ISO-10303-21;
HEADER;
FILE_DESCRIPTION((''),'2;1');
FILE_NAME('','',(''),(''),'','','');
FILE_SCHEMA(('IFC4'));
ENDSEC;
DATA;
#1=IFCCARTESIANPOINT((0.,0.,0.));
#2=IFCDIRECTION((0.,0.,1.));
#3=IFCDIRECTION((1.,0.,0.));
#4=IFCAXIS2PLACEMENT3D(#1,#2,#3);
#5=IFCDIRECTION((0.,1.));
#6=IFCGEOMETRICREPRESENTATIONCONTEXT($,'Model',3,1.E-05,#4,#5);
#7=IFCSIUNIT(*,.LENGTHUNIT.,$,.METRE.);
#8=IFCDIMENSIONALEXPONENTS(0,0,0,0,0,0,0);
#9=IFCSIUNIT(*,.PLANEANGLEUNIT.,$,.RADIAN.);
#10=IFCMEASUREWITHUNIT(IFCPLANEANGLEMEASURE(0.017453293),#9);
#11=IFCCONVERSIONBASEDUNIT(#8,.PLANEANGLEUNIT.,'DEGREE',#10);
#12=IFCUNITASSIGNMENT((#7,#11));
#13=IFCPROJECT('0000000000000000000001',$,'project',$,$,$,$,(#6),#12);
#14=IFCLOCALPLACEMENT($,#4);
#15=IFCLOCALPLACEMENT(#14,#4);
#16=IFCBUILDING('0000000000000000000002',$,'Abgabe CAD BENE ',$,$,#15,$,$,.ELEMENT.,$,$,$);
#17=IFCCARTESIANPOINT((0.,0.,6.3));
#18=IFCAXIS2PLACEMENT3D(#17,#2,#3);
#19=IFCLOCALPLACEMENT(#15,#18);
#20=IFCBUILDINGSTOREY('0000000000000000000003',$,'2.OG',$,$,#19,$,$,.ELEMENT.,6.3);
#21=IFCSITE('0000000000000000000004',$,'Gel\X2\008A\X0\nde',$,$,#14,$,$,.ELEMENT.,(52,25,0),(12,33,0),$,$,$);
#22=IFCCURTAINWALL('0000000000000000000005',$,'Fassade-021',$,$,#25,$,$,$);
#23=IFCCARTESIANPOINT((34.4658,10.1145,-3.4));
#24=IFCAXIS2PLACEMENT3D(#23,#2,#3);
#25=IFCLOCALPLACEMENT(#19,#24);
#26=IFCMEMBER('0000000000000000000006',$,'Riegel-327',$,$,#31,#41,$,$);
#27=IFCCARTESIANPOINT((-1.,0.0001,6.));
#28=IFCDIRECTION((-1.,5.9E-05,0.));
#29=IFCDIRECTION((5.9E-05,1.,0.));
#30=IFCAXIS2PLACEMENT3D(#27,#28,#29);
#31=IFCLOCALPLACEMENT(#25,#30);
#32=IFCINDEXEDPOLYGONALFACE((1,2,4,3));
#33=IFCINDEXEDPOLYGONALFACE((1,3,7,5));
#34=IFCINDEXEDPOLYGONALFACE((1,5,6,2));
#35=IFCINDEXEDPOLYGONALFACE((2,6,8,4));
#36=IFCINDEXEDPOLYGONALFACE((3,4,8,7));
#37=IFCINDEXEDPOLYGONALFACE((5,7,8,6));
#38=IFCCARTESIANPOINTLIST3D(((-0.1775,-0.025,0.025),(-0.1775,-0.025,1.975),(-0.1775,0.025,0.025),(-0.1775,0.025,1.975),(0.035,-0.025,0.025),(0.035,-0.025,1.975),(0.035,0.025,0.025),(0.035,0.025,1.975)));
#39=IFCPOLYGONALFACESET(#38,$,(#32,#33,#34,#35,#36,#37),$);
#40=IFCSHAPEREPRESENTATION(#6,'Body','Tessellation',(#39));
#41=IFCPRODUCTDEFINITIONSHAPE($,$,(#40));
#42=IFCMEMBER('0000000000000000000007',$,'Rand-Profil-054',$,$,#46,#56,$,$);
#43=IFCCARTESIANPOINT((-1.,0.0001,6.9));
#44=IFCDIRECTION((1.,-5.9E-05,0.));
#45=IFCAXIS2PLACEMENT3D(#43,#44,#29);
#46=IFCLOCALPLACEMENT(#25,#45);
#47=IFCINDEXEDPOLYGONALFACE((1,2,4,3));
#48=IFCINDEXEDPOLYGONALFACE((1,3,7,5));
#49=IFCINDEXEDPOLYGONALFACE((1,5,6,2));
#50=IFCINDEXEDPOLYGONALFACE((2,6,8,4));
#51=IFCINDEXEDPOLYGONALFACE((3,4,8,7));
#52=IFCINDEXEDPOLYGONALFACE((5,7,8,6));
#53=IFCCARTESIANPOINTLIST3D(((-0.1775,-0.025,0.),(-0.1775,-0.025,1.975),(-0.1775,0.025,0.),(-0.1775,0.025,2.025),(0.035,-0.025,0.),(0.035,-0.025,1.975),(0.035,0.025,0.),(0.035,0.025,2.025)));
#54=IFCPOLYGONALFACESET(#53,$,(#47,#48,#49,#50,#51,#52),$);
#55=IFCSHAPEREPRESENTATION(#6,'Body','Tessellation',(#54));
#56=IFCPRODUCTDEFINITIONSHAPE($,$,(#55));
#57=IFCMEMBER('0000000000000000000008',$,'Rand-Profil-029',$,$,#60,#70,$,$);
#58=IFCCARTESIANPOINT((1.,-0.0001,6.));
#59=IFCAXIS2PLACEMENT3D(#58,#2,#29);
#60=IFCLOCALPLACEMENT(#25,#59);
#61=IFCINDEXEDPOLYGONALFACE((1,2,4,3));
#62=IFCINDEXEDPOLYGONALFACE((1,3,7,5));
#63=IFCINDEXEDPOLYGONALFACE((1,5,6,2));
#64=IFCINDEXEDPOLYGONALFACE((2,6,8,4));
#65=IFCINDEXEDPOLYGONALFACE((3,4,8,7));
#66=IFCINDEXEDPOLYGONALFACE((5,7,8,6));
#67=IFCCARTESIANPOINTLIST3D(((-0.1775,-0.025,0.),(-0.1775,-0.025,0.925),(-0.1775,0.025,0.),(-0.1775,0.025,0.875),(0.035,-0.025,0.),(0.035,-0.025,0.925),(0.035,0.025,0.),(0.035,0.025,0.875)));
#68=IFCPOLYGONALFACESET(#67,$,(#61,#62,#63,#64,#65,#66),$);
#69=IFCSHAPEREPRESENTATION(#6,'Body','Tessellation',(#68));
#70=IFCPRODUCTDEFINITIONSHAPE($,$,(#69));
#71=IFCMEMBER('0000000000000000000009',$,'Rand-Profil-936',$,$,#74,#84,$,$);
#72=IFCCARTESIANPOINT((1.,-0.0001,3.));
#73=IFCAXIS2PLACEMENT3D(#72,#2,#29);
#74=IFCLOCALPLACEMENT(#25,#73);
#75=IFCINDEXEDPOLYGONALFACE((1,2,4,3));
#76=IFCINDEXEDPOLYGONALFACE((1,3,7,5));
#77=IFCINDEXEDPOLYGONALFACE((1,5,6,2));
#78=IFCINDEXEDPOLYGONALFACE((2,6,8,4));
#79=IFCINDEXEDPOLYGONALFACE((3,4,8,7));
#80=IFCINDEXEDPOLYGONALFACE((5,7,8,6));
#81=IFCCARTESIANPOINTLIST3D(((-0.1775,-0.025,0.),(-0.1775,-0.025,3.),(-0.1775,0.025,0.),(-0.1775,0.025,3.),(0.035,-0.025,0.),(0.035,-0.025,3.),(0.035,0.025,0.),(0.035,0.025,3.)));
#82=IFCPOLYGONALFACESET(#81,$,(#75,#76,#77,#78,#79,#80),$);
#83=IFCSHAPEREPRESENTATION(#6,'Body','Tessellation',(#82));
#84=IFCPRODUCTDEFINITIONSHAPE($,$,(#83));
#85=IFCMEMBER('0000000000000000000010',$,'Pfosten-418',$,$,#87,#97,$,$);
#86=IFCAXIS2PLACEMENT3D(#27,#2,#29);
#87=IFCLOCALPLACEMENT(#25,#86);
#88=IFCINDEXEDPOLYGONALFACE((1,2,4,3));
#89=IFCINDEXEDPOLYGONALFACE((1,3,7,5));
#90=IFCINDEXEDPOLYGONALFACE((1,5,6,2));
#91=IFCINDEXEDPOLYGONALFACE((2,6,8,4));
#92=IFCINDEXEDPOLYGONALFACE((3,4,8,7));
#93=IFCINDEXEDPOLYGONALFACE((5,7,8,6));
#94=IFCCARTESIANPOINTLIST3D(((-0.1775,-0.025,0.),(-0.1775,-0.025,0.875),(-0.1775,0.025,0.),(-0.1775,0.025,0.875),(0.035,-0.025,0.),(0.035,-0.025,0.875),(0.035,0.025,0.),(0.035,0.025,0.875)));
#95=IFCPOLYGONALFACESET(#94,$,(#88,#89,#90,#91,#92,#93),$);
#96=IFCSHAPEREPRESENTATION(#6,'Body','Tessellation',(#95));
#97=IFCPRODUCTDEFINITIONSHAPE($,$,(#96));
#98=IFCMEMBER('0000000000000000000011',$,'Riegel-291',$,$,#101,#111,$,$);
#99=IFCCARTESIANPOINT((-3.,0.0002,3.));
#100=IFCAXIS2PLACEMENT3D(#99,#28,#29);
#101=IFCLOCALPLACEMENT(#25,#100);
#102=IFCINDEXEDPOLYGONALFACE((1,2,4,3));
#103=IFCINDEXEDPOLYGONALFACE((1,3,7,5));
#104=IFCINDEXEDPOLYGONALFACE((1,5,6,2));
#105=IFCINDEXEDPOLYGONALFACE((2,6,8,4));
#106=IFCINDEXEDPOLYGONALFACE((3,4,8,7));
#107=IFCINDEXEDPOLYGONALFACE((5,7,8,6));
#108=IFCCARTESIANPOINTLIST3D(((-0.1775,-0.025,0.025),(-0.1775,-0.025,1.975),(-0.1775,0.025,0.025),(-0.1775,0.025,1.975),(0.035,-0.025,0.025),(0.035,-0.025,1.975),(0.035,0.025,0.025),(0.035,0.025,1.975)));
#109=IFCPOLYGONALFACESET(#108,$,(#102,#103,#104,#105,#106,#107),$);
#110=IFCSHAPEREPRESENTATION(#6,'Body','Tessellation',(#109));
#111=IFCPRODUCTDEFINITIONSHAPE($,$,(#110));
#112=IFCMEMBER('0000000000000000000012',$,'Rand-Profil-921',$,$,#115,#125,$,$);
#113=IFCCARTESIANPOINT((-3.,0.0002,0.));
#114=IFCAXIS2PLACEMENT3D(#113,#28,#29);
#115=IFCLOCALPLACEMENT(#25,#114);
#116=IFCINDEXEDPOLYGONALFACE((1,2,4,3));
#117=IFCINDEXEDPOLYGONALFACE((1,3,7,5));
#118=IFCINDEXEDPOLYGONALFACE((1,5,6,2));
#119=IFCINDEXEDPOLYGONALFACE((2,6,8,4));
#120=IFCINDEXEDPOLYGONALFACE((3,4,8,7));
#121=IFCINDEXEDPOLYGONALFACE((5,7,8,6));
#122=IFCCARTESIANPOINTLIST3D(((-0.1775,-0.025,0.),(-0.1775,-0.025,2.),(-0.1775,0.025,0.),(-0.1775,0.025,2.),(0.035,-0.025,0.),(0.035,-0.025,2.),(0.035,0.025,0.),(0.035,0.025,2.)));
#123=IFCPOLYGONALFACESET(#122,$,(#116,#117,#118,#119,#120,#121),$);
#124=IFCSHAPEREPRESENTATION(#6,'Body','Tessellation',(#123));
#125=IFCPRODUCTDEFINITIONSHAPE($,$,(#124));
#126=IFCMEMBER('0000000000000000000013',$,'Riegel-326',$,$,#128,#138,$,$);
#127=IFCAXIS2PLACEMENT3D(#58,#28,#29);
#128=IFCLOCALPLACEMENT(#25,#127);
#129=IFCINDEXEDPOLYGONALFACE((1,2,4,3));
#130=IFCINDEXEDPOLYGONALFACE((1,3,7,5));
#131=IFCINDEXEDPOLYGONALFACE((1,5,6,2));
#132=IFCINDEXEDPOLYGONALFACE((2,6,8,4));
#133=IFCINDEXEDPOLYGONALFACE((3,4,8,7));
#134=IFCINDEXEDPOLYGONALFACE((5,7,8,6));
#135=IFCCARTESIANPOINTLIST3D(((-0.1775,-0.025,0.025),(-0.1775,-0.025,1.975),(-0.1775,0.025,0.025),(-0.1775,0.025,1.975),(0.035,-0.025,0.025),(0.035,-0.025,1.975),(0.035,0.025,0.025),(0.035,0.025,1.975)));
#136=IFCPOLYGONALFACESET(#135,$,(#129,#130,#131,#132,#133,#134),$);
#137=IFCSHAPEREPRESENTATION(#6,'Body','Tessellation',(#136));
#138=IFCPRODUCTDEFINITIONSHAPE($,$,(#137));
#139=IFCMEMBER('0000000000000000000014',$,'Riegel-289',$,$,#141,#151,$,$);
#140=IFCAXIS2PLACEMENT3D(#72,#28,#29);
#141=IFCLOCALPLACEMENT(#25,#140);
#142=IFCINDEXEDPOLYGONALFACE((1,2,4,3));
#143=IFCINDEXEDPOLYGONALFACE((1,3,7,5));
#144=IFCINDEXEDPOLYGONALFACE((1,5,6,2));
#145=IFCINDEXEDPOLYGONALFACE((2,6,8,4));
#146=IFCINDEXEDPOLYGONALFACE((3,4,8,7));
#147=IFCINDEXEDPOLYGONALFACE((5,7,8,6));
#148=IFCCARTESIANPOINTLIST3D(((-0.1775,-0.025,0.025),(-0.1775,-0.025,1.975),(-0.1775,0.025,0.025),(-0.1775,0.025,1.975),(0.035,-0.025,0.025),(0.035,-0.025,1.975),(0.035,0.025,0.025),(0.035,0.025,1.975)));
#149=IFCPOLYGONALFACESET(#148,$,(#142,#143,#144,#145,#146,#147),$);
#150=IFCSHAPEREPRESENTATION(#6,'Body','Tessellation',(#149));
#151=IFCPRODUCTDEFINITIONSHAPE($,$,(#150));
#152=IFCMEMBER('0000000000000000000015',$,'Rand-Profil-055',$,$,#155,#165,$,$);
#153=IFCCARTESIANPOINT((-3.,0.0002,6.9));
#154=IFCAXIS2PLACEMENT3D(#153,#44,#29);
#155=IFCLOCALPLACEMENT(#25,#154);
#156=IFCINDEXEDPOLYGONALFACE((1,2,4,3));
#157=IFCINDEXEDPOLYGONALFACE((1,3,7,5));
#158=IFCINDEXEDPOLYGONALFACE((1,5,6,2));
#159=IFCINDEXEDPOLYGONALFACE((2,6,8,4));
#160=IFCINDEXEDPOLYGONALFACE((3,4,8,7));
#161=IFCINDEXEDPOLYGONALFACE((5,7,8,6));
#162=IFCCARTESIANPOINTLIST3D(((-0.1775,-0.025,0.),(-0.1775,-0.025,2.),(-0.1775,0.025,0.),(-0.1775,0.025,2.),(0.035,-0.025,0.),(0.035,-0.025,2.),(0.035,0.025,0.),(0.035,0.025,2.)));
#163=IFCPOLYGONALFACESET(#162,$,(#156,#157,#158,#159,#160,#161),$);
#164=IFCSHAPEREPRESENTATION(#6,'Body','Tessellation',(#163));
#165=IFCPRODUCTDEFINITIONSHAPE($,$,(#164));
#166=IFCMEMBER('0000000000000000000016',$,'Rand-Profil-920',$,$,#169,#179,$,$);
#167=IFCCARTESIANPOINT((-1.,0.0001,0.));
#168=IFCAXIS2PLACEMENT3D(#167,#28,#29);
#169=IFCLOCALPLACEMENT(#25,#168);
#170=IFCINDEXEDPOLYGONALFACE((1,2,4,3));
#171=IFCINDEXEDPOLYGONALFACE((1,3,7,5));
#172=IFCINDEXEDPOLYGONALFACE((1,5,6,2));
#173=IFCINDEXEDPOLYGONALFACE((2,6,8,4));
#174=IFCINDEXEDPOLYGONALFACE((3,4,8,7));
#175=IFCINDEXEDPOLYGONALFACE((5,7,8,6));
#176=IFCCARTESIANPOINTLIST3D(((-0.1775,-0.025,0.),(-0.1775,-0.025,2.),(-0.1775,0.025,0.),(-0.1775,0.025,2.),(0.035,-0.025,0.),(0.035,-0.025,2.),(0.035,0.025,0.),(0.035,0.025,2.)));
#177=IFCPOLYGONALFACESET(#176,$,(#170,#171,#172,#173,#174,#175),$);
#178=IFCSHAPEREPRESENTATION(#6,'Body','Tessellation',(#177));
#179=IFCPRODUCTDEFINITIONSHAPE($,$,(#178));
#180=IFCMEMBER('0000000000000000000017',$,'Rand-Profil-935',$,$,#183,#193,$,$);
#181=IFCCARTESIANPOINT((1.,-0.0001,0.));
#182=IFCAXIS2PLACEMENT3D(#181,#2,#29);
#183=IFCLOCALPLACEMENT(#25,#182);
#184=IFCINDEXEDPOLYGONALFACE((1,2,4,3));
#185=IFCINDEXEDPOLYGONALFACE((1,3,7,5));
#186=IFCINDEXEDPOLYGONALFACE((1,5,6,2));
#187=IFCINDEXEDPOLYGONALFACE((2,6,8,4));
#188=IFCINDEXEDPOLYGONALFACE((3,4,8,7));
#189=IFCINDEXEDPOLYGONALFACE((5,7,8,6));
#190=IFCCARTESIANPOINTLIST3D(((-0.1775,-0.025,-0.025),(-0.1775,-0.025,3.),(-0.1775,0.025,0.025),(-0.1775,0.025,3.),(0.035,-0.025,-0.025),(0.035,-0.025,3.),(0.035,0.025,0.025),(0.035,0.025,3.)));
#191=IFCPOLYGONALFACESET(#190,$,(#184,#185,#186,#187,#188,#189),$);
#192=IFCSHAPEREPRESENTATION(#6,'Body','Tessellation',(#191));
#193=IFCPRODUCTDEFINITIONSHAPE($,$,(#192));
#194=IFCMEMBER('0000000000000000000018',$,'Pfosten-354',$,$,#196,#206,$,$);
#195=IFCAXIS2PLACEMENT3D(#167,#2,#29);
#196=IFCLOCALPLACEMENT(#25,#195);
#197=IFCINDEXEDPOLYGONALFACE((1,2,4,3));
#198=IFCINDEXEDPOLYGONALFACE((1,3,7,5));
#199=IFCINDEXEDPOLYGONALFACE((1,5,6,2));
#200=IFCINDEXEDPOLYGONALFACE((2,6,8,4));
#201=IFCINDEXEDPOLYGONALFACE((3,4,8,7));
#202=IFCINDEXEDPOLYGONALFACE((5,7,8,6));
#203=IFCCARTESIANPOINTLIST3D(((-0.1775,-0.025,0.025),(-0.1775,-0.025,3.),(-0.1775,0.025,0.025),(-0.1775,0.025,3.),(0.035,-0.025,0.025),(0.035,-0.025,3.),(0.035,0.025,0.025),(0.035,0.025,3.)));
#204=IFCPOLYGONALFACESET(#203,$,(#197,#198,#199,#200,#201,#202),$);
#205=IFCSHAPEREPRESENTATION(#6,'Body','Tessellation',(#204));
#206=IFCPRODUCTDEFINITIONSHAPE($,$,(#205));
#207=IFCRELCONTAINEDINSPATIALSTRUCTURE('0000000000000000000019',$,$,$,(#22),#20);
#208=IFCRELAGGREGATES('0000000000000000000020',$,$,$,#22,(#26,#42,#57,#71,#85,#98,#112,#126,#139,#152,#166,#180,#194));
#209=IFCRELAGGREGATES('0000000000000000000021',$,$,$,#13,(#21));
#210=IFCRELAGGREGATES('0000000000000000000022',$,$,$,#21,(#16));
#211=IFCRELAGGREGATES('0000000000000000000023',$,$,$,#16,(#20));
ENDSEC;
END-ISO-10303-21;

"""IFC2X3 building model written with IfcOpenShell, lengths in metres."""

from ifc_helpers import new_model, entity, si_unit, converted_unit, direction, frame, origin_with_axes, place, context, project, spatial, polyline, outline, extrude, clip, halfspace, element, aggregate, save


model = new_model("IFC2X3")

# Units and contexts
model_context = context("Model", 3, precision=1e-05, world=origin_with_axes(), true_north=direction((0.0, 1.0)))
ifc_project = project(units=[si_unit("LENGTHUNIT", "METRE"), converted_unit("PLANEANGLEUNIT", "DEGREE", entity("IfcPlaneAngleMeasure", 0.017453293), si_unit("PLANEANGLEUNIT", "RADIAN"), dimensions=[0, 0, 0, 0, 0, 0, 0])], contexts=[model_context])

# Site, building, storey
site_placement = place(None, origin_with_axes())
site = spatial("IfcSite", under=ifc_project, at=site_placement, Name="Gel\u008ande", CompositionType="ELEMENT", RefLatitude=(52, 25, 0), RefLongitude=(12, 33, 0))
building_placement = place(site_placement, origin_with_axes())
building = spatial("IfcBuilding", under=site, at=building_placement, Name="Abgabe CAD BENE ", CompositionType="ELEMENT")
storey_placement = place(building_placement, frame((0.0, 0.0, 6.3), z_axis=(0.0, 0.0, 1.0), x_axis=(1.0, 0.0, 0.0)))
storey = spatial("IfcBuildingStorey", under=building, at=storey_placement, Name="2.OG", CompositionType="ELEMENT", Elevation=6.3)

# Curtain wall, members
curtain_wall_placement = place(storey_placement, frame((34.4658, 10.1145, -3.4), z_axis=(0.0, 0.0, 1.0), x_axis=(1.0, 0.0, 0.0)))
curtain_wall = element("IfcCurtainWall", 1, at=curtain_wall_placement, inside=storey, Name="Fassade-021")
member_1_placement = place(curtain_wall_placement, frame((-1.0, 0.0001, 6.0), z_axis=(-1.0, 0.000059, 0.0), x_axis=(0.000059, 1.0, 0.0)))
member_1 = element("IfcMember", 2, at=member_1_placement, Name="Riegel-327", context=model_context, shape_type="SweptSolid", body=[
    extrude(outline(polyline([(-0.1775, -0.025), (0.035, -0.025), (0.035, 0.025), (-0.1775, 0.025), (-0.1775, -0.025)])), frame((0.0, 0.0, 0.025), z_axis=(0.0, 0.0, 1.0), x_axis=(1.0, 0.0, 0.0)), (0.0, 0.0, 1.0), 1.95),
])
member_2_placement = place(curtain_wall_placement, frame((-1.0, 0.0001, 6.9), z_axis=(1.0, -0.000059, 0.0), x_axis=(0.000059, 1.0, 0.0)))
member_2 = element("IfcMember", 3, at=member_2_placement, Name="Rand-Profil-054", context=model_context, shape_type="Clipping", body=[
    clip(extrude(outline(polyline([(0.1775, 0.025), (-0.035, 0.025), (-0.035, -0.025), (0.1775, -0.025), (0.1775, 0.025)])), frame((0.0, 0.0, 0.0), z_axis=(0.0, 0.0, 1.0), x_axis=(-1.0, 0.0, 0.0)), (0.0, 0.0, 1.0), 2.025), halfspace(frame((0.0, -1.0, 1.0), z_axis=(0.0, 0.707107, -0.707107), x_axis=(0.0, -0.707107, -0.707107)), True)),
])
member_3_placement = place(curtain_wall_placement, frame((1.0, -0.0001, 6.0), z_axis=(0.0, 0.0, 1.0), x_axis=(0.000059, 1.0, 0.0)))
member_3 = element("IfcMember", 4, at=member_3_placement, Name="Rand-Profil-029", context=model_context, shape_type="Clipping", body=[
    clip(extrude(outline(polyline([(0.025, -0.1775), (0.025, 0.035), (-0.025, 0.035), (-0.025, -0.1775), (0.025, -0.1775)])), frame((0.0, 0.0, 0.0), z_axis=(0.0, 0.0, 1.0), x_axis=(0.000059, -1.0, 0.0)), (0.0, 0.0, 1.0), 0.925), halfspace(frame((0.0, 0.45, 0.45), z_axis=(0.0, -0.707107, -0.707107), x_axis=(0.0, -0.707107, 0.707107)), True)),
])
member_4_placement = place(curtain_wall_placement, frame((1.0, -0.0001, 3.0), z_axis=(0.0, 0.0, 1.0), x_axis=(0.000059, 1.0, 0.0)))
member_4 = element("IfcMember", 5, at=member_4_placement, Name="Rand-Profil-936", context=model_context, shape_type="SweptSolid", body=[
    extrude(outline(polyline([(0.025, -0.1775), (0.025, 0.035), (-0.025, 0.035), (-0.025, -0.1775), (0.025, -0.1775)])), frame((0.0, 0.0, 0.0), z_axis=(0.0, 0.0, 1.0), x_axis=(0.000059, -1.0, 0.0)), (0.0, 0.0, 1.0), 3.0),
])
member_5_placement = place(curtain_wall_placement, frame((-1.0, 0.0001, 6.0), z_axis=(0.0, 0.0, 1.0), x_axis=(0.000059, 1.0, 0.0)))
member_5 = element("IfcMember", 6, at=member_5_placement, Name="Pfosten-418", context=model_context, shape_type="SweptSolid", body=[
    extrude(outline(polyline([(0.025, -0.1775), (0.025, 0.035), (-0.025, 0.035), (-0.025, -0.1775), (0.025, -0.1775)])), frame((0.0, 0.0, 0.0), z_axis=(0.0, 0.0, 1.0), x_axis=(0.000059, -1.0, 0.0)), (0.0, 0.0, 1.0), 0.875),
])
member_6_placement = place(curtain_wall_placement, frame((-3.0, 0.0002, 3.0), z_axis=(-1.0, 0.000059, 0.0), x_axis=(0.000059, 1.0, 0.0)))
member_6 = element("IfcMember", 7, at=member_6_placement, Name="Riegel-291", context=model_context, shape_type="SweptSolid", body=[
    extrude(outline(polyline([(-0.1775, -0.025), (0.035, -0.025), (0.035, 0.025), (-0.1775, 0.025), (-0.1775, -0.025)])), frame((0.0, 0.0, 0.025), z_axis=(0.0, 0.0, 1.0), x_axis=(1.0, 0.0, 0.0)), (0.0, 0.0, 1.0), 1.95),
])
member_7_placement = place(curtain_wall_placement, frame((-3.0, 0.0002, 0.0), z_axis=(-1.0, 0.000059, 0.0), x_axis=(0.000059, 1.0, 0.0)))
member_7 = element("IfcMember", 8, at=member_7_placement, Name="Rand-Profil-921", context=model_context, shape_type="SweptSolid", body=[
    extrude(outline(polyline([(-0.1775, -0.025), (0.035, -0.025), (0.035, 0.025), (-0.1775, 0.025), (-0.1775, -0.025)])), origin_with_axes(), (0.0, 0.0, 1.0), 2.0),
])
member_8_placement = place(curtain_wall_placement, frame((1.0, -0.0001, 6.0), z_axis=(-1.0, 0.000059, 0.0), x_axis=(0.000059, 1.0, 0.0)))
member_8 = element("IfcMember", 9, at=member_8_placement, Name="Riegel-326", context=model_context, shape_type="SweptSolid", body=[
    extrude(outline(polyline([(-0.1775, -0.025), (0.035, -0.025), (0.035, 0.025), (-0.1775, 0.025), (-0.1775, -0.025)])), frame((0.0, 0.0, 0.025), z_axis=(0.0, 0.0, 1.0), x_axis=(1.0, 0.0, 0.0)), (0.0, 0.0, 1.0), 1.95),
])
member_9_placement = place(curtain_wall_placement, frame((1.0, -0.0001, 3.0), z_axis=(-1.0, 0.000059, 0.0), x_axis=(0.000059, 1.0, 0.0)))
member_9 = element("IfcMember", 10, at=member_9_placement, Name="Riegel-289", context=model_context, shape_type="SweptSolid", body=[
    extrude(outline(polyline([(-0.1775, -0.025), (0.035, -0.025), (0.035, 0.025), (-0.1775, 0.025), (-0.1775, -0.025)])), frame((0.0, 0.0, 0.025), z_axis=(0.0, 0.0, 1.0), x_axis=(1.0, 0.0, 0.0)), (0.0, 0.0, 1.0), 1.95),
])
member_10_placement = place(curtain_wall_placement, frame((-3.0, 0.0002, 6.9), z_axis=(1.0, -0.000059, 0.0), x_axis=(0.000059, 1.0, 0.0)))
member_10 = element("IfcMember", 11, at=member_10_placement, Name="Rand-Profil-055", context=model_context, shape_type="SweptSolid", body=[
    extrude(outline(polyline([(0.1775, 0.025), (-0.035, 0.025), (-0.035, -0.025), (0.1775, -0.025), (0.1775, 0.025)])), frame((0.0, 0.0, 0.0), z_axis=(0.0, 0.0, 1.0), x_axis=(-1.0, 0.0, 0.0)), (0.0, 0.0, 1.0), 2.0),
])
member_11_placement = place(curtain_wall_placement, frame((-1.0, 0.0001, 0.0), z_axis=(-1.0, 0.000059, 0.0), x_axis=(0.000059, 1.0, 0.0)))
member_11 = element("IfcMember", 12, at=member_11_placement, Name="Rand-Profil-920", context=model_context, shape_type="SweptSolid", body=[
    extrude(outline(polyline([(-0.1775, -0.025), (0.035, -0.025), (0.035, 0.025), (-0.1775, 0.025), (-0.1775, -0.025)])), origin_with_axes(), (0.0, 0.0, 1.0), 2.0),
])
member_12_placement = place(curtain_wall_placement, frame((1.0, -0.0001, 0.0), z_axis=(0.0, 0.0, 1.0), x_axis=(0.000059, 1.0, 0.0)))
member_12 = element("IfcMember", 13, at=member_12_placement, Name="Rand-Profil-935", context=model_context, shape_type="Clipping", body=[
    clip(extrude(outline(polyline([(0.025, -0.1775), (0.025, 0.035), (-0.025, 0.035), (-0.025, -0.1775), (0.025, -0.1775)])), frame((0.0, 0.0, -0.025), z_axis=(0.0, 0.0, 1.0), x_axis=(0.000059, -1.0, 0.0)), (0.0, 0.0, 1.0), 3.025), halfspace(frame((0.0, 0.0, 0.0), z_axis=(0.0, -0.707107, 0.707107), x_axis=(0.0, 0.707107, 0.707107)), True)),
])
member_13_placement = place(curtain_wall_placement, frame((-1.0, 0.0001, 0.0), z_axis=(0.0, 0.0, 1.0), x_axis=(0.000059, 1.0, 0.0)))
member_13 = element("IfcMember", 14, at=member_13_placement, Name="Pfosten-354", context=model_context, shape_type="SweptSolid", body=[
    extrude(outline(polyline([(0.025, -0.1775), (0.025, 0.035), (-0.025, 0.035), (-0.025, -0.1775), (0.025, -0.1775)])), frame((0.0, 0.0, 0.025), z_axis=(0.0, 0.0, 1.0), x_axis=(0.000059, -1.0, 0.0)), (0.0, 0.0, 1.0), 2.975),
])
aggregate(curtain_wall, [member_1, member_2, member_3, member_4, member_5, member_6, member_7, member_8, member_9, member_10, member_11, member_12, member_13])

save(model, "model.ifc")
